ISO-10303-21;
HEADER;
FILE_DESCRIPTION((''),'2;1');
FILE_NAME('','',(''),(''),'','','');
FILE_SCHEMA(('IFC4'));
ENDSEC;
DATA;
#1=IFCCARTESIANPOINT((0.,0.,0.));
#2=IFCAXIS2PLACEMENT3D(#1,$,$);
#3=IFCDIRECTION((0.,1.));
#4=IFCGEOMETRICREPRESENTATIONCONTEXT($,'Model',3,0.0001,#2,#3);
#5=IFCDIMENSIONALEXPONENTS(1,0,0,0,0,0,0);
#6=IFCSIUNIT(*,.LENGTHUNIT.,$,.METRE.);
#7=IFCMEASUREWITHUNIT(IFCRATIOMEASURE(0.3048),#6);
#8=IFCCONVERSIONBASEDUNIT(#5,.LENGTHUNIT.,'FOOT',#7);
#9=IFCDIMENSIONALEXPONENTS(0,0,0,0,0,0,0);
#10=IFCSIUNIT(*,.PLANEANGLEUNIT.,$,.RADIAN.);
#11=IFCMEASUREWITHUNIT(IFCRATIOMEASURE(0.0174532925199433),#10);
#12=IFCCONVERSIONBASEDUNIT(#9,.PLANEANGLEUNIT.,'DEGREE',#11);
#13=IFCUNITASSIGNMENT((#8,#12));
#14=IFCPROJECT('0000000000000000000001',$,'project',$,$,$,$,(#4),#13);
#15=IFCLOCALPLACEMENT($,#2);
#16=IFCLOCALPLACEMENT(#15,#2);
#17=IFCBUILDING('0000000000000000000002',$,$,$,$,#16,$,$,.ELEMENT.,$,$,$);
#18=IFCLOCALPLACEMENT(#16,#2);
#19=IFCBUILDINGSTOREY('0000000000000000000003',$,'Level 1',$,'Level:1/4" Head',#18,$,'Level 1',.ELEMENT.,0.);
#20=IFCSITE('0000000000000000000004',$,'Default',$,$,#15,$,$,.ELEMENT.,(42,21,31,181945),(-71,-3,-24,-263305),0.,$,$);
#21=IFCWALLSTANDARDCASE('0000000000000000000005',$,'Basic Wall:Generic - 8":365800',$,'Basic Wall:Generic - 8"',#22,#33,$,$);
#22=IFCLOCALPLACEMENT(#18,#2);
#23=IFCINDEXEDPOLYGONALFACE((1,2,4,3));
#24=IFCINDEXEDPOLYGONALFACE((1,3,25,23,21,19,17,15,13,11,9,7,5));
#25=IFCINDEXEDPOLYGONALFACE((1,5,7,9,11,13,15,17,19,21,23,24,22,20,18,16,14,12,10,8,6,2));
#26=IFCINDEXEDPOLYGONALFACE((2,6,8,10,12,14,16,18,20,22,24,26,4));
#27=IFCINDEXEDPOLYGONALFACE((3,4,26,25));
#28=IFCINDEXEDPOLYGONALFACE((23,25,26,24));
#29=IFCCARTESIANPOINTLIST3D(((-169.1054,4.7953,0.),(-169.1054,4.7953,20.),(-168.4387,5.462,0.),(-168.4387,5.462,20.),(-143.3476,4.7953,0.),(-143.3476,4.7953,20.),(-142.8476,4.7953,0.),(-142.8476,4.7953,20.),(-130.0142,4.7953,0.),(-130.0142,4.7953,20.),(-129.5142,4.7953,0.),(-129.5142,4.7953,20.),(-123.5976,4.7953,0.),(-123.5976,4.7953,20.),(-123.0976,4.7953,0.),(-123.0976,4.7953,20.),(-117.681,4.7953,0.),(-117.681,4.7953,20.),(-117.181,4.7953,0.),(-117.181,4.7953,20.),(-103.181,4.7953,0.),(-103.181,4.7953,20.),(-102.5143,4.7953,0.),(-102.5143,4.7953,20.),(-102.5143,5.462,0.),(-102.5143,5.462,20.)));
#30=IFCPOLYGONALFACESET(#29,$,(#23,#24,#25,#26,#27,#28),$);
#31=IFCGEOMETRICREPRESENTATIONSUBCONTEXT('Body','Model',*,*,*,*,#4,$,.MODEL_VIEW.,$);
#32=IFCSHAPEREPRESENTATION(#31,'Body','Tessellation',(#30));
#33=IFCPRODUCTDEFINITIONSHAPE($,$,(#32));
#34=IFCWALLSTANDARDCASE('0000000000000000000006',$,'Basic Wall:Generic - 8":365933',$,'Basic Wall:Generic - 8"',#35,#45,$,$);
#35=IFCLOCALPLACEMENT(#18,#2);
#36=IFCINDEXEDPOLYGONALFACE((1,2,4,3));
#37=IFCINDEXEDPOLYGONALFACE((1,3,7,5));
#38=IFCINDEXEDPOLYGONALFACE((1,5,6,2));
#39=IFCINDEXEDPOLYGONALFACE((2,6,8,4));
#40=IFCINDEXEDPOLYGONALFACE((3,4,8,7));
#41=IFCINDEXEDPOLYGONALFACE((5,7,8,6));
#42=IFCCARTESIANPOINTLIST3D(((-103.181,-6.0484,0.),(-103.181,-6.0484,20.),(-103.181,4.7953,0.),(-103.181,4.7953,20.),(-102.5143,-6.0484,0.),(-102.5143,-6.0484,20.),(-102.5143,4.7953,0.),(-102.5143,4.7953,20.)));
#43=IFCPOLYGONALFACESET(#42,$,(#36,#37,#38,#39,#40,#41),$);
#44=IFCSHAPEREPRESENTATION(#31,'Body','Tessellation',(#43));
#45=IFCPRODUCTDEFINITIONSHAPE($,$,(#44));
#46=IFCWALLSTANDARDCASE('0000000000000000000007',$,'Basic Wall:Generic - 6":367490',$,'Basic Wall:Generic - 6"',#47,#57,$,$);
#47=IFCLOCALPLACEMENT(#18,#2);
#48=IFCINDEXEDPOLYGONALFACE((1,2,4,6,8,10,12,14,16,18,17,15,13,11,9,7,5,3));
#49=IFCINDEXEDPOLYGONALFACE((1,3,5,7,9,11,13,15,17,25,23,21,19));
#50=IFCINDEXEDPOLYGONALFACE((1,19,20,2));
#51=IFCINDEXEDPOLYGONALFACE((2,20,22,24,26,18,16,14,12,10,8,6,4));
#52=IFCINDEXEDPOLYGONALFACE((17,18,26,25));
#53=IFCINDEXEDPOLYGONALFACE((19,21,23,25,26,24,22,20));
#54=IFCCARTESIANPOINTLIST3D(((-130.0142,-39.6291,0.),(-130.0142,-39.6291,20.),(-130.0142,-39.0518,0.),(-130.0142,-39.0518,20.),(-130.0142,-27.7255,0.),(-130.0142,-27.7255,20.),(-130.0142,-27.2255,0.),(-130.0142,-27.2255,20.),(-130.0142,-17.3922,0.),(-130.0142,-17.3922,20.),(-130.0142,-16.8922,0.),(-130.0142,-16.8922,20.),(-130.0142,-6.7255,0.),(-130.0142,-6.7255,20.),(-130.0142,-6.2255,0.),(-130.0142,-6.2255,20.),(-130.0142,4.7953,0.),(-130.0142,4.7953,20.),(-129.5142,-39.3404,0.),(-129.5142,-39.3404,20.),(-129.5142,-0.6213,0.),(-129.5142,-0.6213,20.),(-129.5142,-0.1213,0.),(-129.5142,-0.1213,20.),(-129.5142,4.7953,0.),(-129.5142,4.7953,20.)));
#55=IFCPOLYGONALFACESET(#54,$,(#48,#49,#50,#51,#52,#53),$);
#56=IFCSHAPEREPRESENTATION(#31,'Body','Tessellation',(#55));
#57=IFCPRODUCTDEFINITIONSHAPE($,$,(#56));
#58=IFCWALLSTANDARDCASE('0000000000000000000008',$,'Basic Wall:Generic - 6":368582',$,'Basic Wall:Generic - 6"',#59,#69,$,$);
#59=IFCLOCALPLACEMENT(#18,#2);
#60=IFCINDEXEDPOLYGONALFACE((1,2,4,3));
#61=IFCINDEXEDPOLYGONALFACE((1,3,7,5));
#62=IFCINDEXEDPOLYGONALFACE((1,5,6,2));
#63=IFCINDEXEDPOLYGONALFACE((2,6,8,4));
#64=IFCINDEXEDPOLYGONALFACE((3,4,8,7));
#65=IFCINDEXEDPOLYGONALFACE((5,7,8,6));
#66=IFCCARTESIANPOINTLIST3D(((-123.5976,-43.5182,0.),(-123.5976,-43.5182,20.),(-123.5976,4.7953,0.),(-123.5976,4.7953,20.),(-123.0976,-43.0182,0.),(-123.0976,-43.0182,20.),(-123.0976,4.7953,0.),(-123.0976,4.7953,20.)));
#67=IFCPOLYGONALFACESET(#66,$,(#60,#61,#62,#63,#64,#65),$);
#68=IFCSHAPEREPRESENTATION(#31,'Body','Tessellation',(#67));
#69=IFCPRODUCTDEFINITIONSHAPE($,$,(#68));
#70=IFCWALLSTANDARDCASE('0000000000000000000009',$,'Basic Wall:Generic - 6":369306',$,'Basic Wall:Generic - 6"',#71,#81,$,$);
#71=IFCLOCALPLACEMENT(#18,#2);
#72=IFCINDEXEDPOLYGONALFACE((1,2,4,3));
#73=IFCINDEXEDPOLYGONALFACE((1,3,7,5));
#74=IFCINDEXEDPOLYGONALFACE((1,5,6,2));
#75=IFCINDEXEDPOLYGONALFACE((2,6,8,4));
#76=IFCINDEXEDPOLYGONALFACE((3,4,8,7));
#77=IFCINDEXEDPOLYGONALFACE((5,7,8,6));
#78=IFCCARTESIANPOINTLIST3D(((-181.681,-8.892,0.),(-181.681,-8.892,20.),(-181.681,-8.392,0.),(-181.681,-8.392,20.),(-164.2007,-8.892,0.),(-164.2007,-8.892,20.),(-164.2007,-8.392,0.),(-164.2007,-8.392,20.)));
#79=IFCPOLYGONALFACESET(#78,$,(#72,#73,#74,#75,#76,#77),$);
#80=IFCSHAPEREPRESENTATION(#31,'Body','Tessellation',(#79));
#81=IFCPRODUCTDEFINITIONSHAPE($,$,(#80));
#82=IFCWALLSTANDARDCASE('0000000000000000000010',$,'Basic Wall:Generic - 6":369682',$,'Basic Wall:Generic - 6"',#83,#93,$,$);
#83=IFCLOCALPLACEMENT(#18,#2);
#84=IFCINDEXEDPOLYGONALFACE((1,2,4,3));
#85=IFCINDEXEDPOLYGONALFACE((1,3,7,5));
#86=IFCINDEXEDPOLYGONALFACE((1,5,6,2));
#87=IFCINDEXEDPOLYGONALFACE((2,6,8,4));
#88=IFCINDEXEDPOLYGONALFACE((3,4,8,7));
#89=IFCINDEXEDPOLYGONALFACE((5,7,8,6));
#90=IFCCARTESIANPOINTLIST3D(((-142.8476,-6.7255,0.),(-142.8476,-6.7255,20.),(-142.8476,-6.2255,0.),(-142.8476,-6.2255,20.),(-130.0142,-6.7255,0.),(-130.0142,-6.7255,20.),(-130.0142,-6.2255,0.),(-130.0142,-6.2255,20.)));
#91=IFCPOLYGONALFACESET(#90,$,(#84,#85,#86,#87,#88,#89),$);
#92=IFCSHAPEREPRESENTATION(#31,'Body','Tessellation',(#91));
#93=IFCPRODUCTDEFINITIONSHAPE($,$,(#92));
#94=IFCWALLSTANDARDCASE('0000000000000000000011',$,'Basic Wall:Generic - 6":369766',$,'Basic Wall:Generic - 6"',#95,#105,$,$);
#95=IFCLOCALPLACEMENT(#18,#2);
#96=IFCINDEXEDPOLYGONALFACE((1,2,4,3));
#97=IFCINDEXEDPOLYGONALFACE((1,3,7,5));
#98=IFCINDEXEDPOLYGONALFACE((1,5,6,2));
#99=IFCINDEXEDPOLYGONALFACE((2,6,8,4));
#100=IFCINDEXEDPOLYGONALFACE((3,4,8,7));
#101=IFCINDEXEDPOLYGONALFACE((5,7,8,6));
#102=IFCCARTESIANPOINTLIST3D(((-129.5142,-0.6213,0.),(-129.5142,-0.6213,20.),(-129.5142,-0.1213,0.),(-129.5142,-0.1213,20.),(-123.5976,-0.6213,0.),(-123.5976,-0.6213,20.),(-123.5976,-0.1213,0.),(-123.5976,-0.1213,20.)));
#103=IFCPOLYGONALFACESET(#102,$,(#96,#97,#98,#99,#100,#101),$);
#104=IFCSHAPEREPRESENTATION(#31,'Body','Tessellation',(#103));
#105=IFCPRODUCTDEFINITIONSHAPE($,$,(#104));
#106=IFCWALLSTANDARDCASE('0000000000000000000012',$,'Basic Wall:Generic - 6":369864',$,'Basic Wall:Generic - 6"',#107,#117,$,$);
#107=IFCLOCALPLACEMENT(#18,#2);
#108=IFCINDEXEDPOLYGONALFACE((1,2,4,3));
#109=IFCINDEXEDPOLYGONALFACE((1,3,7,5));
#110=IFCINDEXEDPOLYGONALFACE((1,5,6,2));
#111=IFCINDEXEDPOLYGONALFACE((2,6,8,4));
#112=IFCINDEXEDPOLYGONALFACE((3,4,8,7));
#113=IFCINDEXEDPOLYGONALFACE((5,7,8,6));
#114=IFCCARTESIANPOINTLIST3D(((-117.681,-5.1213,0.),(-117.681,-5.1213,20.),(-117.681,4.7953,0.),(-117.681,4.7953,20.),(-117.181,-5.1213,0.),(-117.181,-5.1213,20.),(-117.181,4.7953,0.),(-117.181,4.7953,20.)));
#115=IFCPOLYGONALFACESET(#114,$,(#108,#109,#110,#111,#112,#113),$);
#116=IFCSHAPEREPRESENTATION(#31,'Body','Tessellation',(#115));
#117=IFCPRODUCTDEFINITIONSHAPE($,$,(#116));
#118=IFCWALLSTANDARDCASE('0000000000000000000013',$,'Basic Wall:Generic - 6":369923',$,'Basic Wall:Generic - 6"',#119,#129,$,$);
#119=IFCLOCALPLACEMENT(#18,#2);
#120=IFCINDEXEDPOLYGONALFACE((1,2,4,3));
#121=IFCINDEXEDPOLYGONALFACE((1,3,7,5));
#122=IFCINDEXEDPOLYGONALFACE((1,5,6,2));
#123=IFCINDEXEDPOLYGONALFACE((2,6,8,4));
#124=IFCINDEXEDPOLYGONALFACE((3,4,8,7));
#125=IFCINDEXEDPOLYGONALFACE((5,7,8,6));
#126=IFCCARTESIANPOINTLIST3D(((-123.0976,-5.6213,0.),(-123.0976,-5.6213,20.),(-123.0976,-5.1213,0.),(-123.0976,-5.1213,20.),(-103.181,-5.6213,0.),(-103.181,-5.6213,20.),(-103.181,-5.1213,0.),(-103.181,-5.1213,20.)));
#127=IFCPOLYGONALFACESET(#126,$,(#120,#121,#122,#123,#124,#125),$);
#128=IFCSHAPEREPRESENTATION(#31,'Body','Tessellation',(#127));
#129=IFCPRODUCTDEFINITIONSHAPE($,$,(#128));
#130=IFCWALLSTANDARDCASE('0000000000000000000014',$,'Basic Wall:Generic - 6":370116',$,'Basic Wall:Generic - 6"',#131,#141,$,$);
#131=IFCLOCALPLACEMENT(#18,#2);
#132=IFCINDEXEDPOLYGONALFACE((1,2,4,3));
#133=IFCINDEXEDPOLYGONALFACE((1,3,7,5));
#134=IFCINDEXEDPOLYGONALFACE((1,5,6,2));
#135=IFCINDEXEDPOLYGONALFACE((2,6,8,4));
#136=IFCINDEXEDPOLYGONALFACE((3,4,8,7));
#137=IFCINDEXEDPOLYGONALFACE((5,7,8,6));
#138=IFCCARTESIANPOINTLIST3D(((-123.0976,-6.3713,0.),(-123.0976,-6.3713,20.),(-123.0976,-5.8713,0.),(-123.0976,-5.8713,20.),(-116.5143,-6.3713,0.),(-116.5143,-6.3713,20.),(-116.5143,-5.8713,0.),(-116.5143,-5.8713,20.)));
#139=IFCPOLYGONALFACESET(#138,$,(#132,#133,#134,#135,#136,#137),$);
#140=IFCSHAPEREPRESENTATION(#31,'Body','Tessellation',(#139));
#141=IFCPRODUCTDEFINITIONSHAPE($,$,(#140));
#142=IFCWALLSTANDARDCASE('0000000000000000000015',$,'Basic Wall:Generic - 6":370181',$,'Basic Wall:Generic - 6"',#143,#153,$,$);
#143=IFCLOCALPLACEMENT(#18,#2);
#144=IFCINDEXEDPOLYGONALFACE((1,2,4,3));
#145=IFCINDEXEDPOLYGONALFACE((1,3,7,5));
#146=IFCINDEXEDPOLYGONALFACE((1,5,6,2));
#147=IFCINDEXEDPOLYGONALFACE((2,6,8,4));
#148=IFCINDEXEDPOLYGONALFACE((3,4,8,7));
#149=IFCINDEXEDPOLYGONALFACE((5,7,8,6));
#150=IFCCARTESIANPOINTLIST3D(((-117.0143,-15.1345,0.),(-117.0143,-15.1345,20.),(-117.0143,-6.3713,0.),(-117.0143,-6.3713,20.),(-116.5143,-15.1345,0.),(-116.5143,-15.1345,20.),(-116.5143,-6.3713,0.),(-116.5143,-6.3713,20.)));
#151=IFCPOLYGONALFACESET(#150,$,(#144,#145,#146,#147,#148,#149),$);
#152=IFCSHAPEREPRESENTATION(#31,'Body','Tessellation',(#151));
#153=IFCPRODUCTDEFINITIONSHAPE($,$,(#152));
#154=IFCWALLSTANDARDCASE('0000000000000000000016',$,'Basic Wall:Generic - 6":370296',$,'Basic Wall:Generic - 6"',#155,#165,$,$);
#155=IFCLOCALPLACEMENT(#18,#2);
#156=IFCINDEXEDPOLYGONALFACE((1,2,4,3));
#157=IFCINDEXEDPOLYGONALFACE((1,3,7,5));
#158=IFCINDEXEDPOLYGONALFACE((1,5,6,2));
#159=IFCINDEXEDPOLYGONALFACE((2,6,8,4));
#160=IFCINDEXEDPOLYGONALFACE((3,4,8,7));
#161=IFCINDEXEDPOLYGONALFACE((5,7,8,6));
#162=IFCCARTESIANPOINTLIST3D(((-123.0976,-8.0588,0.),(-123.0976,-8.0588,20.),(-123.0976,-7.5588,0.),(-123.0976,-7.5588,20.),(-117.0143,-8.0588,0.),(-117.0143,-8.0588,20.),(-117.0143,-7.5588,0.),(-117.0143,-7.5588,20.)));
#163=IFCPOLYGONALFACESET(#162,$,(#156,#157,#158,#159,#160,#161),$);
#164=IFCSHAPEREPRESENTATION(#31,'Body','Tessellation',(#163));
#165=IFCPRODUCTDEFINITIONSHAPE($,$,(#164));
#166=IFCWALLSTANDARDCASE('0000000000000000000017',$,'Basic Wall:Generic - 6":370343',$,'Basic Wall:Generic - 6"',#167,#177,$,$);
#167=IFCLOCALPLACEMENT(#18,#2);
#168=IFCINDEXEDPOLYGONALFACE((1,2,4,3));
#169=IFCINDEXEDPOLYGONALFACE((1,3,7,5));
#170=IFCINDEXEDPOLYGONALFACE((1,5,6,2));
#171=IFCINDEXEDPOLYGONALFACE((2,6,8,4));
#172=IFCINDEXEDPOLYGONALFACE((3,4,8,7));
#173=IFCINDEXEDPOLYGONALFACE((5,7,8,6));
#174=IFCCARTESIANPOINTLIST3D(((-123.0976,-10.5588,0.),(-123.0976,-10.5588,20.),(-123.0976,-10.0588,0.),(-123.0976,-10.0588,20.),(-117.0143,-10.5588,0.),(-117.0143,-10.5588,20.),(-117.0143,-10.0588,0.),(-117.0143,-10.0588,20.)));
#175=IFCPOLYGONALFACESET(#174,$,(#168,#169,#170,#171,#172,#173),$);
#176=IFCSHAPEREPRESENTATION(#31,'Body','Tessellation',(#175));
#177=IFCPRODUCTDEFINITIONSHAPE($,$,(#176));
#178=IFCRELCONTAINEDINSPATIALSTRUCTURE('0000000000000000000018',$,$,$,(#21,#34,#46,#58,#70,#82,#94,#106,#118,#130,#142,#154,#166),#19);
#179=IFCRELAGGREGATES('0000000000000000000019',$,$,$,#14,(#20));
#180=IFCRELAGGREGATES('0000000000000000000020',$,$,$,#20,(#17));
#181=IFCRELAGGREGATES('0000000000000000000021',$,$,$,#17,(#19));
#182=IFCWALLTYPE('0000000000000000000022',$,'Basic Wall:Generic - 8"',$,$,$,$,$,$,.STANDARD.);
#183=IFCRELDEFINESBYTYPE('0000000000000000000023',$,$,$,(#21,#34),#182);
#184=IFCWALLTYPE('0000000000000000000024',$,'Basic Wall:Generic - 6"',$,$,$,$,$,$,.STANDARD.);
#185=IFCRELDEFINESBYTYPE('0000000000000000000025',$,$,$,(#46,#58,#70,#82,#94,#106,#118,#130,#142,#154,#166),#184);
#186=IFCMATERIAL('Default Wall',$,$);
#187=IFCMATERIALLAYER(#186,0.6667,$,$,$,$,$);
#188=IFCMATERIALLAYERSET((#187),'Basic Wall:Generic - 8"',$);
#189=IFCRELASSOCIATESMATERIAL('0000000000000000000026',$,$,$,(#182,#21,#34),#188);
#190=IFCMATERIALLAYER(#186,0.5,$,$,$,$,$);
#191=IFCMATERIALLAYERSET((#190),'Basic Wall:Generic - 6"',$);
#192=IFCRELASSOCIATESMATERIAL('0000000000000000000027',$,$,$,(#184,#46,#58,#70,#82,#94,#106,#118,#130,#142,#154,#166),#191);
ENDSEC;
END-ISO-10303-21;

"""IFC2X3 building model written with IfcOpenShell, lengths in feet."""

from ifc_helpers import new_model, entity, si_unit, converted_unit, direction, frame, frame_2d, origin, place, context, subcontext, project, spatial, polyline, rectangle, outline, extrude, material, layer, layer_set, layer_usage, type_object, element, save


model = new_model("IFC2X3")

# Units and contexts
model_context = context("Model", 3, precision=0.0001, world=origin(), true_north=direction((0.0, 1.0)))
body_context = subcontext(model_context, "Body", "Model", "MODEL_VIEW")
ifc_project = project(units=[converted_unit("LENGTHUNIT", "FOOT", entity("IfcRatioMeasure", 0.3048), si_unit("LENGTHUNIT", "METRE"), dimensions=[1, 0, 0, 0, 0, 0, 0]), converted_unit("PLANEANGLEUNIT", "DEGREE", entity("IfcRatioMeasure", 0.0174532925199433), si_unit("PLANEANGLEUNIT", "RADIAN"), dimensions=[0, 0, 0, 0, 0, 0, 0])], contexts=[model_context])

# Site, building, storey
site_placement = place(None, origin())
site = spatial("IfcSite", under=ifc_project, at=site_placement, Name="Default", CompositionType="ELEMENT", RefLatitude=(42, 21, 31, 181945), RefLongitude=(-71, -3, -24, -263305), RefElevation=0.0)
building_placement = place(site_placement, origin())
building = spatial("IfcBuilding", under=site, at=building_placement, CompositionType="ELEMENT")
storey_placement = place(building_placement, origin())
storey = spatial("IfcBuildingStorey", under=building, at=storey_placement, Name="Level 1", ObjectType="Level:1/4\" Head", LongName="Level 1", CompositionType="ELEMENT", Elevation=0.0)

# Walls
ifc_material = material(Name="Default Wall")
ifc_layer_1 = layer(ifc_material, 0.6667)
ifc_layer_set_1 = layer_set([ifc_layer_1], Name="Basic Wall:Generic - 8\"")
wall_type_1 = type_object("IfcWallType", Name="Basic Wall:Generic - 8\"", PredefinedType="STANDARD", material=ifc_layer_set_1)
ifc_layer_usage_1 = layer_usage(ifc_layer_set_1, "AXIS2", "NEGATIVE", 0.3333)
wall_1_placement = place(storey_placement, frame((-169.1054, 5.1287, 0.0)))
element("IfcWallStandardCase", 1, at=wall_1_placement, inside=storey, type_object=wall_type_1, material=ifc_layer_usage_1, Name="Basic Wall:Generic - 8\":365800", ObjectType="Basic Wall:Generic - 8\"", context=body_context, shape_type="SweptSolid", body=[
    extrude(outline(polyline([(66.5911, -0.3333), (66.5911, 0.3333), (0.6667, 0.3333), (0.0, -0.3333), (25.7578, -0.3333), (26.2578, -0.3333), (39.0912, -0.3333), (39.5912, -0.3333), (45.5078, -0.3333), (46.0078, -0.3333), (51.4244, -0.3333), (51.9244, -0.3333), (65.9244, -0.3333), (66.5911, -0.3333)])), origin(), (0.0, 0.0, 1.0), 20.0),
])
ifc_layer_usage_2 = layer_usage(ifc_layer_set_1, "AXIS2", "NEGATIVE", 0.3333)
wall_2_placement = place(storey_placement, frame((-102.8476, 4.7953, 0.0), z_axis=(0.0, 0.0, 1.0), x_axis=(0.0, -1.0, 0.0)))
element("IfcWallStandardCase", 2, at=wall_2_placement, inside=storey, type_object=wall_type_1, material=ifc_layer_usage_2, Name="Basic Wall:Generic - 8\":365933", ObjectType="Basic Wall:Generic - 8\"", context=body_context, shape_type="SweptSolid", body=[
    extrude(rectangle(XDim=10.8438, YDim=0.6667, at=frame_2d((5.4219, 0.0), x_axis=(-1.0, 0.0))), origin(), (0.0, 0.0, 1.0), 20.0),
])
ifc_layer_2 = layer(ifc_material, 0.5)
ifc_layer_set_2 = layer_set([ifc_layer_2], Name="Basic Wall:Generic - 6\"")
ifc_layer_usage_3 = layer_usage(ifc_layer_set_2, "AXIS2", "NEGATIVE", 0.25)
wall_type_2 = type_object("IfcWallType", Name="Basic Wall:Generic - 6\"", PredefinedType="STANDARD", material=ifc_layer_set_2)
wall_3_placement = place(storey_placement, frame((-129.7642, 4.7953, 0.0), z_axis=(0.0, 0.0, 1.0), x_axis=(0.0, -1.0, 0.0)))
element("IfcWallStandardCase", 3, at=wall_3_placement, inside=storey, type_object=wall_type_2, material=ifc_layer_usage_3, Name="Basic Wall:Generic - 6\":367490", ObjectType="Basic Wall:Generic - 6\"", context=body_context, shape_type="SweptSolid", body=[
    extrude(outline(polyline([(44.4245, -0.25), (44.1358, 0.25), (5.4167, 0.25), (4.9167, 0.25), (0.0, 0.25), (0.0, -0.25), (11.0208, -0.25), (11.5208, -0.25), (21.6875, -0.25), (22.1875, -0.25), (32.0208, -0.25), (32.5208, -0.25), (43.8471, -0.25), (44.4245, -0.25)])), origin(), (0.0, 0.0, 1.0), 20.0),
])
ifc_layer_usage_4 = layer_usage(ifc_layer_set_2, "AXIS2", "NEGATIVE", 0.25)
wall_4_placement = place(storey_placement, frame((-123.3476, 4.7953, 0.0), z_axis=(0.0, 0.0, 1.0), x_axis=(0.0, -1.0, 0.0)))
element("IfcWallStandardCase", 4, at=wall_4_placement, inside=storey, type_object=wall_type_2, material=ifc_layer_usage_4, Name="Basic Wall:Generic - 6\":368582", ObjectType="Basic Wall:Generic - 6\"", context=body_context, shape_type="SweptSolid", body=[
    extrude(outline(polyline([(48.3136, -0.25), (47.8136, 0.25), (0.0, 0.25), (0.0, -0.25), (48.3136, -0.25)])), origin(), (0.0, 0.0, 1.0), 20.0),
])
ifc_layer_usage_5 = layer_usage(ifc_layer_set_2, "AXIS2", "NEGATIVE", 0.25)
wall_5_placement = place(storey_placement, frame((-181.681, -8.642, 0.0)))
element("IfcWallStandardCase", 5, at=wall_5_placement, inside=storey, type_object=wall_type_2, material=ifc_layer_usage_5, Name="Basic Wall:Generic - 6\":369306", ObjectType="Basic Wall:Generic - 6\"", context=body_context, shape_type="SweptSolid", body=[
    extrude(rectangle(XDim=17.4803, YDim=0.5, at=frame_2d((8.7402, 0.0), x_axis=(-1.0, 0.0))), origin(), (0.0, 0.0, 1.0), 20.0),
])
ifc_layer_usage_6 = layer_usage(ifc_layer_set_2, "AXIS2", "NEGATIVE", 0.25)
wall_6_placement = place(storey_placement, frame((-130.0142, -6.4755, 0.0), z_axis=(0.0, 0.0, 1.0), x_axis=(-1.0, 0.0, 0.0)))
element("IfcWallStandardCase", 6, at=wall_6_placement, inside=storey, type_object=wall_type_2, material=ifc_layer_usage_6, Name="Basic Wall:Generic - 6\":369682", ObjectType="Basic Wall:Generic - 6\"", context=body_context, shape_type="SweptSolid", body=[
    extrude(rectangle(XDim=12.8333, YDim=0.5, at=frame_2d((6.4167, 0.0), x_axis=(-1.0, 0.0))), origin(), (0.0, 0.0, 1.0), 20.0),
])
ifc_layer_usage_7 = layer_usage(ifc_layer_set_2, "AXIS2", "NEGATIVE", 0.25)
wall_7_placement = place(storey_placement, frame((-129.5142, -0.3713, 0.0)))
element("IfcWallStandardCase", 7, at=wall_7_placement, inside=storey, type_object=wall_type_2, material=ifc_layer_usage_7, Name="Basic Wall:Generic - 6\":369766", ObjectType="Basic Wall:Generic - 6\"", context=body_context, shape_type="SweptSolid", body=[
    extrude(rectangle(XDim=5.9166, YDim=0.5, at=frame_2d((2.9583, 0.0), x_axis=(-1.0, 0.0))), origin(), (0.0, 0.0, 1.0), 20.0),
])
ifc_layer_usage_8 = layer_usage(ifc_layer_set_2, "AXIS2", "NEGATIVE", 0.25)
wall_8_placement = place(storey_placement, frame((-117.431, 4.7953, 0.0), z_axis=(0.0, 0.0, 1.0), x_axis=(0.0, -1.0, 0.0)))
element("IfcWallStandardCase", 8, at=wall_8_placement, inside=storey, type_object=wall_type_2, material=ifc_layer_usage_8, Name="Basic Wall:Generic - 6\":369864", ObjectType="Basic Wall:Generic - 6\"", context=body_context, shape_type="SweptSolid", body=[
    extrude(rectangle(XDim=9.9167, YDim=0.5, at=frame_2d((4.9583, 0.0), x_axis=(-1.0, 0.0))), origin(), (0.0, 0.0, 1.0), 20.0),
])
ifc_layer_usage_9 = layer_usage(ifc_layer_set_2, "AXIS2", "NEGATIVE", 0.25)
wall_9_placement = place(storey_placement, frame((-103.181, -5.3713, 0.0), z_axis=(0.0, 0.0, 1.0), x_axis=(-1.0, 0.0, 0.0)))
element("IfcWallStandardCase", 9, at=wall_9_placement, inside=storey, type_object=wall_type_2, material=ifc_layer_usage_9, Name="Basic Wall:Generic - 6\":369923", ObjectType="Basic Wall:Generic - 6\"", context=body_context, shape_type="SweptSolid", body=[
    extrude(rectangle(XDim=19.9167, YDim=0.5, at=frame_2d((9.9583, 0.0), x_axis=(-1.0, 0.0))), origin(), (0.0, 0.0, 1.0), 20.0),
])
ifc_layer_usage_10 = layer_usage(ifc_layer_set_2, "AXIS2", "NEGATIVE", 0.25)
wall_10_placement = place(storey_placement, frame((-123.0976, -6.1213, 0.0)))
element("IfcWallStandardCase", 10, at=wall_10_placement, inside=storey, type_object=wall_type_2, material=ifc_layer_usage_10, Name="Basic Wall:Generic - 6\":370116", ObjectType="Basic Wall:Generic - 6\"", context=body_context, shape_type="SweptSolid", body=[
    extrude(rectangle(XDim=6.5833, YDim=0.5, at=frame_2d((3.2917, 0.0), x_axis=(-1.0, 0.0))), origin(), (0.0, 0.0, 1.0), 20.0),
])
ifc_layer_usage_11 = layer_usage(ifc_layer_set_2, "AXIS2", "NEGATIVE", 0.25)
wall_11_placement = place(storey_placement, frame((-116.7643, -6.3713, 0.0), z_axis=(0.0, 0.0, 1.0), x_axis=(0.0, -1.0, 0.0)))
element("IfcWallStandardCase", 11, at=wall_11_placement, inside=storey, type_object=wall_type_2, material=ifc_layer_usage_11, Name="Basic Wall:Generic - 6\":370181", ObjectType="Basic Wall:Generic - 6\"", context=body_context, shape_type="SweptSolid", body=[
    extrude(rectangle(XDim=8.7632, YDim=0.5, at=frame_2d((4.3816, 0.0), x_axis=(-1.0, 0.0))), origin(), (0.0, 0.0, 1.0), 20.0),
])
ifc_layer_usage_12 = layer_usage(ifc_layer_set_2, "AXIS2", "NEGATIVE", 0.25)
wall_12_placement = place(storey_placement, frame((-123.0976, -7.8088, 0.0)))
element("IfcWallStandardCase", 12, at=wall_12_placement, inside=storey, type_object=wall_type_2, material=ifc_layer_usage_12, Name="Basic Wall:Generic - 6\":370296", ObjectType="Basic Wall:Generic - 6\"", context=body_context, shape_type="SweptSolid", body=[
    extrude(rectangle(XDim=6.0833, YDim=0.5, at=frame_2d((3.0417, 0.0), x_axis=(-1.0, 0.0))), origin(), (0.0, 0.0, 1.0), 20.0),
])
ifc_layer_usage_13 = layer_usage(ifc_layer_set_2, "AXIS2", "NEGATIVE", 0.25)
wall_13_placement = place(storey_placement, frame((-123.0976, -10.3088, 0.0)))
element("IfcWallStandardCase", 13, at=wall_13_placement, inside=storey, type_object=wall_type_2, material=ifc_layer_usage_13, Name="Basic Wall:Generic - 6\":370343", ObjectType="Basic Wall:Generic - 6\"", context=body_context, shape_type="SweptSolid", body=[
    extrude(rectangle(XDim=6.0833, YDim=0.5, at=frame_2d((3.0417, 0.0), x_axis=(-1.0, 0.0))), origin(), (0.0, 0.0, 1.0), 20.0),
])

save(model, "model.ifc")
